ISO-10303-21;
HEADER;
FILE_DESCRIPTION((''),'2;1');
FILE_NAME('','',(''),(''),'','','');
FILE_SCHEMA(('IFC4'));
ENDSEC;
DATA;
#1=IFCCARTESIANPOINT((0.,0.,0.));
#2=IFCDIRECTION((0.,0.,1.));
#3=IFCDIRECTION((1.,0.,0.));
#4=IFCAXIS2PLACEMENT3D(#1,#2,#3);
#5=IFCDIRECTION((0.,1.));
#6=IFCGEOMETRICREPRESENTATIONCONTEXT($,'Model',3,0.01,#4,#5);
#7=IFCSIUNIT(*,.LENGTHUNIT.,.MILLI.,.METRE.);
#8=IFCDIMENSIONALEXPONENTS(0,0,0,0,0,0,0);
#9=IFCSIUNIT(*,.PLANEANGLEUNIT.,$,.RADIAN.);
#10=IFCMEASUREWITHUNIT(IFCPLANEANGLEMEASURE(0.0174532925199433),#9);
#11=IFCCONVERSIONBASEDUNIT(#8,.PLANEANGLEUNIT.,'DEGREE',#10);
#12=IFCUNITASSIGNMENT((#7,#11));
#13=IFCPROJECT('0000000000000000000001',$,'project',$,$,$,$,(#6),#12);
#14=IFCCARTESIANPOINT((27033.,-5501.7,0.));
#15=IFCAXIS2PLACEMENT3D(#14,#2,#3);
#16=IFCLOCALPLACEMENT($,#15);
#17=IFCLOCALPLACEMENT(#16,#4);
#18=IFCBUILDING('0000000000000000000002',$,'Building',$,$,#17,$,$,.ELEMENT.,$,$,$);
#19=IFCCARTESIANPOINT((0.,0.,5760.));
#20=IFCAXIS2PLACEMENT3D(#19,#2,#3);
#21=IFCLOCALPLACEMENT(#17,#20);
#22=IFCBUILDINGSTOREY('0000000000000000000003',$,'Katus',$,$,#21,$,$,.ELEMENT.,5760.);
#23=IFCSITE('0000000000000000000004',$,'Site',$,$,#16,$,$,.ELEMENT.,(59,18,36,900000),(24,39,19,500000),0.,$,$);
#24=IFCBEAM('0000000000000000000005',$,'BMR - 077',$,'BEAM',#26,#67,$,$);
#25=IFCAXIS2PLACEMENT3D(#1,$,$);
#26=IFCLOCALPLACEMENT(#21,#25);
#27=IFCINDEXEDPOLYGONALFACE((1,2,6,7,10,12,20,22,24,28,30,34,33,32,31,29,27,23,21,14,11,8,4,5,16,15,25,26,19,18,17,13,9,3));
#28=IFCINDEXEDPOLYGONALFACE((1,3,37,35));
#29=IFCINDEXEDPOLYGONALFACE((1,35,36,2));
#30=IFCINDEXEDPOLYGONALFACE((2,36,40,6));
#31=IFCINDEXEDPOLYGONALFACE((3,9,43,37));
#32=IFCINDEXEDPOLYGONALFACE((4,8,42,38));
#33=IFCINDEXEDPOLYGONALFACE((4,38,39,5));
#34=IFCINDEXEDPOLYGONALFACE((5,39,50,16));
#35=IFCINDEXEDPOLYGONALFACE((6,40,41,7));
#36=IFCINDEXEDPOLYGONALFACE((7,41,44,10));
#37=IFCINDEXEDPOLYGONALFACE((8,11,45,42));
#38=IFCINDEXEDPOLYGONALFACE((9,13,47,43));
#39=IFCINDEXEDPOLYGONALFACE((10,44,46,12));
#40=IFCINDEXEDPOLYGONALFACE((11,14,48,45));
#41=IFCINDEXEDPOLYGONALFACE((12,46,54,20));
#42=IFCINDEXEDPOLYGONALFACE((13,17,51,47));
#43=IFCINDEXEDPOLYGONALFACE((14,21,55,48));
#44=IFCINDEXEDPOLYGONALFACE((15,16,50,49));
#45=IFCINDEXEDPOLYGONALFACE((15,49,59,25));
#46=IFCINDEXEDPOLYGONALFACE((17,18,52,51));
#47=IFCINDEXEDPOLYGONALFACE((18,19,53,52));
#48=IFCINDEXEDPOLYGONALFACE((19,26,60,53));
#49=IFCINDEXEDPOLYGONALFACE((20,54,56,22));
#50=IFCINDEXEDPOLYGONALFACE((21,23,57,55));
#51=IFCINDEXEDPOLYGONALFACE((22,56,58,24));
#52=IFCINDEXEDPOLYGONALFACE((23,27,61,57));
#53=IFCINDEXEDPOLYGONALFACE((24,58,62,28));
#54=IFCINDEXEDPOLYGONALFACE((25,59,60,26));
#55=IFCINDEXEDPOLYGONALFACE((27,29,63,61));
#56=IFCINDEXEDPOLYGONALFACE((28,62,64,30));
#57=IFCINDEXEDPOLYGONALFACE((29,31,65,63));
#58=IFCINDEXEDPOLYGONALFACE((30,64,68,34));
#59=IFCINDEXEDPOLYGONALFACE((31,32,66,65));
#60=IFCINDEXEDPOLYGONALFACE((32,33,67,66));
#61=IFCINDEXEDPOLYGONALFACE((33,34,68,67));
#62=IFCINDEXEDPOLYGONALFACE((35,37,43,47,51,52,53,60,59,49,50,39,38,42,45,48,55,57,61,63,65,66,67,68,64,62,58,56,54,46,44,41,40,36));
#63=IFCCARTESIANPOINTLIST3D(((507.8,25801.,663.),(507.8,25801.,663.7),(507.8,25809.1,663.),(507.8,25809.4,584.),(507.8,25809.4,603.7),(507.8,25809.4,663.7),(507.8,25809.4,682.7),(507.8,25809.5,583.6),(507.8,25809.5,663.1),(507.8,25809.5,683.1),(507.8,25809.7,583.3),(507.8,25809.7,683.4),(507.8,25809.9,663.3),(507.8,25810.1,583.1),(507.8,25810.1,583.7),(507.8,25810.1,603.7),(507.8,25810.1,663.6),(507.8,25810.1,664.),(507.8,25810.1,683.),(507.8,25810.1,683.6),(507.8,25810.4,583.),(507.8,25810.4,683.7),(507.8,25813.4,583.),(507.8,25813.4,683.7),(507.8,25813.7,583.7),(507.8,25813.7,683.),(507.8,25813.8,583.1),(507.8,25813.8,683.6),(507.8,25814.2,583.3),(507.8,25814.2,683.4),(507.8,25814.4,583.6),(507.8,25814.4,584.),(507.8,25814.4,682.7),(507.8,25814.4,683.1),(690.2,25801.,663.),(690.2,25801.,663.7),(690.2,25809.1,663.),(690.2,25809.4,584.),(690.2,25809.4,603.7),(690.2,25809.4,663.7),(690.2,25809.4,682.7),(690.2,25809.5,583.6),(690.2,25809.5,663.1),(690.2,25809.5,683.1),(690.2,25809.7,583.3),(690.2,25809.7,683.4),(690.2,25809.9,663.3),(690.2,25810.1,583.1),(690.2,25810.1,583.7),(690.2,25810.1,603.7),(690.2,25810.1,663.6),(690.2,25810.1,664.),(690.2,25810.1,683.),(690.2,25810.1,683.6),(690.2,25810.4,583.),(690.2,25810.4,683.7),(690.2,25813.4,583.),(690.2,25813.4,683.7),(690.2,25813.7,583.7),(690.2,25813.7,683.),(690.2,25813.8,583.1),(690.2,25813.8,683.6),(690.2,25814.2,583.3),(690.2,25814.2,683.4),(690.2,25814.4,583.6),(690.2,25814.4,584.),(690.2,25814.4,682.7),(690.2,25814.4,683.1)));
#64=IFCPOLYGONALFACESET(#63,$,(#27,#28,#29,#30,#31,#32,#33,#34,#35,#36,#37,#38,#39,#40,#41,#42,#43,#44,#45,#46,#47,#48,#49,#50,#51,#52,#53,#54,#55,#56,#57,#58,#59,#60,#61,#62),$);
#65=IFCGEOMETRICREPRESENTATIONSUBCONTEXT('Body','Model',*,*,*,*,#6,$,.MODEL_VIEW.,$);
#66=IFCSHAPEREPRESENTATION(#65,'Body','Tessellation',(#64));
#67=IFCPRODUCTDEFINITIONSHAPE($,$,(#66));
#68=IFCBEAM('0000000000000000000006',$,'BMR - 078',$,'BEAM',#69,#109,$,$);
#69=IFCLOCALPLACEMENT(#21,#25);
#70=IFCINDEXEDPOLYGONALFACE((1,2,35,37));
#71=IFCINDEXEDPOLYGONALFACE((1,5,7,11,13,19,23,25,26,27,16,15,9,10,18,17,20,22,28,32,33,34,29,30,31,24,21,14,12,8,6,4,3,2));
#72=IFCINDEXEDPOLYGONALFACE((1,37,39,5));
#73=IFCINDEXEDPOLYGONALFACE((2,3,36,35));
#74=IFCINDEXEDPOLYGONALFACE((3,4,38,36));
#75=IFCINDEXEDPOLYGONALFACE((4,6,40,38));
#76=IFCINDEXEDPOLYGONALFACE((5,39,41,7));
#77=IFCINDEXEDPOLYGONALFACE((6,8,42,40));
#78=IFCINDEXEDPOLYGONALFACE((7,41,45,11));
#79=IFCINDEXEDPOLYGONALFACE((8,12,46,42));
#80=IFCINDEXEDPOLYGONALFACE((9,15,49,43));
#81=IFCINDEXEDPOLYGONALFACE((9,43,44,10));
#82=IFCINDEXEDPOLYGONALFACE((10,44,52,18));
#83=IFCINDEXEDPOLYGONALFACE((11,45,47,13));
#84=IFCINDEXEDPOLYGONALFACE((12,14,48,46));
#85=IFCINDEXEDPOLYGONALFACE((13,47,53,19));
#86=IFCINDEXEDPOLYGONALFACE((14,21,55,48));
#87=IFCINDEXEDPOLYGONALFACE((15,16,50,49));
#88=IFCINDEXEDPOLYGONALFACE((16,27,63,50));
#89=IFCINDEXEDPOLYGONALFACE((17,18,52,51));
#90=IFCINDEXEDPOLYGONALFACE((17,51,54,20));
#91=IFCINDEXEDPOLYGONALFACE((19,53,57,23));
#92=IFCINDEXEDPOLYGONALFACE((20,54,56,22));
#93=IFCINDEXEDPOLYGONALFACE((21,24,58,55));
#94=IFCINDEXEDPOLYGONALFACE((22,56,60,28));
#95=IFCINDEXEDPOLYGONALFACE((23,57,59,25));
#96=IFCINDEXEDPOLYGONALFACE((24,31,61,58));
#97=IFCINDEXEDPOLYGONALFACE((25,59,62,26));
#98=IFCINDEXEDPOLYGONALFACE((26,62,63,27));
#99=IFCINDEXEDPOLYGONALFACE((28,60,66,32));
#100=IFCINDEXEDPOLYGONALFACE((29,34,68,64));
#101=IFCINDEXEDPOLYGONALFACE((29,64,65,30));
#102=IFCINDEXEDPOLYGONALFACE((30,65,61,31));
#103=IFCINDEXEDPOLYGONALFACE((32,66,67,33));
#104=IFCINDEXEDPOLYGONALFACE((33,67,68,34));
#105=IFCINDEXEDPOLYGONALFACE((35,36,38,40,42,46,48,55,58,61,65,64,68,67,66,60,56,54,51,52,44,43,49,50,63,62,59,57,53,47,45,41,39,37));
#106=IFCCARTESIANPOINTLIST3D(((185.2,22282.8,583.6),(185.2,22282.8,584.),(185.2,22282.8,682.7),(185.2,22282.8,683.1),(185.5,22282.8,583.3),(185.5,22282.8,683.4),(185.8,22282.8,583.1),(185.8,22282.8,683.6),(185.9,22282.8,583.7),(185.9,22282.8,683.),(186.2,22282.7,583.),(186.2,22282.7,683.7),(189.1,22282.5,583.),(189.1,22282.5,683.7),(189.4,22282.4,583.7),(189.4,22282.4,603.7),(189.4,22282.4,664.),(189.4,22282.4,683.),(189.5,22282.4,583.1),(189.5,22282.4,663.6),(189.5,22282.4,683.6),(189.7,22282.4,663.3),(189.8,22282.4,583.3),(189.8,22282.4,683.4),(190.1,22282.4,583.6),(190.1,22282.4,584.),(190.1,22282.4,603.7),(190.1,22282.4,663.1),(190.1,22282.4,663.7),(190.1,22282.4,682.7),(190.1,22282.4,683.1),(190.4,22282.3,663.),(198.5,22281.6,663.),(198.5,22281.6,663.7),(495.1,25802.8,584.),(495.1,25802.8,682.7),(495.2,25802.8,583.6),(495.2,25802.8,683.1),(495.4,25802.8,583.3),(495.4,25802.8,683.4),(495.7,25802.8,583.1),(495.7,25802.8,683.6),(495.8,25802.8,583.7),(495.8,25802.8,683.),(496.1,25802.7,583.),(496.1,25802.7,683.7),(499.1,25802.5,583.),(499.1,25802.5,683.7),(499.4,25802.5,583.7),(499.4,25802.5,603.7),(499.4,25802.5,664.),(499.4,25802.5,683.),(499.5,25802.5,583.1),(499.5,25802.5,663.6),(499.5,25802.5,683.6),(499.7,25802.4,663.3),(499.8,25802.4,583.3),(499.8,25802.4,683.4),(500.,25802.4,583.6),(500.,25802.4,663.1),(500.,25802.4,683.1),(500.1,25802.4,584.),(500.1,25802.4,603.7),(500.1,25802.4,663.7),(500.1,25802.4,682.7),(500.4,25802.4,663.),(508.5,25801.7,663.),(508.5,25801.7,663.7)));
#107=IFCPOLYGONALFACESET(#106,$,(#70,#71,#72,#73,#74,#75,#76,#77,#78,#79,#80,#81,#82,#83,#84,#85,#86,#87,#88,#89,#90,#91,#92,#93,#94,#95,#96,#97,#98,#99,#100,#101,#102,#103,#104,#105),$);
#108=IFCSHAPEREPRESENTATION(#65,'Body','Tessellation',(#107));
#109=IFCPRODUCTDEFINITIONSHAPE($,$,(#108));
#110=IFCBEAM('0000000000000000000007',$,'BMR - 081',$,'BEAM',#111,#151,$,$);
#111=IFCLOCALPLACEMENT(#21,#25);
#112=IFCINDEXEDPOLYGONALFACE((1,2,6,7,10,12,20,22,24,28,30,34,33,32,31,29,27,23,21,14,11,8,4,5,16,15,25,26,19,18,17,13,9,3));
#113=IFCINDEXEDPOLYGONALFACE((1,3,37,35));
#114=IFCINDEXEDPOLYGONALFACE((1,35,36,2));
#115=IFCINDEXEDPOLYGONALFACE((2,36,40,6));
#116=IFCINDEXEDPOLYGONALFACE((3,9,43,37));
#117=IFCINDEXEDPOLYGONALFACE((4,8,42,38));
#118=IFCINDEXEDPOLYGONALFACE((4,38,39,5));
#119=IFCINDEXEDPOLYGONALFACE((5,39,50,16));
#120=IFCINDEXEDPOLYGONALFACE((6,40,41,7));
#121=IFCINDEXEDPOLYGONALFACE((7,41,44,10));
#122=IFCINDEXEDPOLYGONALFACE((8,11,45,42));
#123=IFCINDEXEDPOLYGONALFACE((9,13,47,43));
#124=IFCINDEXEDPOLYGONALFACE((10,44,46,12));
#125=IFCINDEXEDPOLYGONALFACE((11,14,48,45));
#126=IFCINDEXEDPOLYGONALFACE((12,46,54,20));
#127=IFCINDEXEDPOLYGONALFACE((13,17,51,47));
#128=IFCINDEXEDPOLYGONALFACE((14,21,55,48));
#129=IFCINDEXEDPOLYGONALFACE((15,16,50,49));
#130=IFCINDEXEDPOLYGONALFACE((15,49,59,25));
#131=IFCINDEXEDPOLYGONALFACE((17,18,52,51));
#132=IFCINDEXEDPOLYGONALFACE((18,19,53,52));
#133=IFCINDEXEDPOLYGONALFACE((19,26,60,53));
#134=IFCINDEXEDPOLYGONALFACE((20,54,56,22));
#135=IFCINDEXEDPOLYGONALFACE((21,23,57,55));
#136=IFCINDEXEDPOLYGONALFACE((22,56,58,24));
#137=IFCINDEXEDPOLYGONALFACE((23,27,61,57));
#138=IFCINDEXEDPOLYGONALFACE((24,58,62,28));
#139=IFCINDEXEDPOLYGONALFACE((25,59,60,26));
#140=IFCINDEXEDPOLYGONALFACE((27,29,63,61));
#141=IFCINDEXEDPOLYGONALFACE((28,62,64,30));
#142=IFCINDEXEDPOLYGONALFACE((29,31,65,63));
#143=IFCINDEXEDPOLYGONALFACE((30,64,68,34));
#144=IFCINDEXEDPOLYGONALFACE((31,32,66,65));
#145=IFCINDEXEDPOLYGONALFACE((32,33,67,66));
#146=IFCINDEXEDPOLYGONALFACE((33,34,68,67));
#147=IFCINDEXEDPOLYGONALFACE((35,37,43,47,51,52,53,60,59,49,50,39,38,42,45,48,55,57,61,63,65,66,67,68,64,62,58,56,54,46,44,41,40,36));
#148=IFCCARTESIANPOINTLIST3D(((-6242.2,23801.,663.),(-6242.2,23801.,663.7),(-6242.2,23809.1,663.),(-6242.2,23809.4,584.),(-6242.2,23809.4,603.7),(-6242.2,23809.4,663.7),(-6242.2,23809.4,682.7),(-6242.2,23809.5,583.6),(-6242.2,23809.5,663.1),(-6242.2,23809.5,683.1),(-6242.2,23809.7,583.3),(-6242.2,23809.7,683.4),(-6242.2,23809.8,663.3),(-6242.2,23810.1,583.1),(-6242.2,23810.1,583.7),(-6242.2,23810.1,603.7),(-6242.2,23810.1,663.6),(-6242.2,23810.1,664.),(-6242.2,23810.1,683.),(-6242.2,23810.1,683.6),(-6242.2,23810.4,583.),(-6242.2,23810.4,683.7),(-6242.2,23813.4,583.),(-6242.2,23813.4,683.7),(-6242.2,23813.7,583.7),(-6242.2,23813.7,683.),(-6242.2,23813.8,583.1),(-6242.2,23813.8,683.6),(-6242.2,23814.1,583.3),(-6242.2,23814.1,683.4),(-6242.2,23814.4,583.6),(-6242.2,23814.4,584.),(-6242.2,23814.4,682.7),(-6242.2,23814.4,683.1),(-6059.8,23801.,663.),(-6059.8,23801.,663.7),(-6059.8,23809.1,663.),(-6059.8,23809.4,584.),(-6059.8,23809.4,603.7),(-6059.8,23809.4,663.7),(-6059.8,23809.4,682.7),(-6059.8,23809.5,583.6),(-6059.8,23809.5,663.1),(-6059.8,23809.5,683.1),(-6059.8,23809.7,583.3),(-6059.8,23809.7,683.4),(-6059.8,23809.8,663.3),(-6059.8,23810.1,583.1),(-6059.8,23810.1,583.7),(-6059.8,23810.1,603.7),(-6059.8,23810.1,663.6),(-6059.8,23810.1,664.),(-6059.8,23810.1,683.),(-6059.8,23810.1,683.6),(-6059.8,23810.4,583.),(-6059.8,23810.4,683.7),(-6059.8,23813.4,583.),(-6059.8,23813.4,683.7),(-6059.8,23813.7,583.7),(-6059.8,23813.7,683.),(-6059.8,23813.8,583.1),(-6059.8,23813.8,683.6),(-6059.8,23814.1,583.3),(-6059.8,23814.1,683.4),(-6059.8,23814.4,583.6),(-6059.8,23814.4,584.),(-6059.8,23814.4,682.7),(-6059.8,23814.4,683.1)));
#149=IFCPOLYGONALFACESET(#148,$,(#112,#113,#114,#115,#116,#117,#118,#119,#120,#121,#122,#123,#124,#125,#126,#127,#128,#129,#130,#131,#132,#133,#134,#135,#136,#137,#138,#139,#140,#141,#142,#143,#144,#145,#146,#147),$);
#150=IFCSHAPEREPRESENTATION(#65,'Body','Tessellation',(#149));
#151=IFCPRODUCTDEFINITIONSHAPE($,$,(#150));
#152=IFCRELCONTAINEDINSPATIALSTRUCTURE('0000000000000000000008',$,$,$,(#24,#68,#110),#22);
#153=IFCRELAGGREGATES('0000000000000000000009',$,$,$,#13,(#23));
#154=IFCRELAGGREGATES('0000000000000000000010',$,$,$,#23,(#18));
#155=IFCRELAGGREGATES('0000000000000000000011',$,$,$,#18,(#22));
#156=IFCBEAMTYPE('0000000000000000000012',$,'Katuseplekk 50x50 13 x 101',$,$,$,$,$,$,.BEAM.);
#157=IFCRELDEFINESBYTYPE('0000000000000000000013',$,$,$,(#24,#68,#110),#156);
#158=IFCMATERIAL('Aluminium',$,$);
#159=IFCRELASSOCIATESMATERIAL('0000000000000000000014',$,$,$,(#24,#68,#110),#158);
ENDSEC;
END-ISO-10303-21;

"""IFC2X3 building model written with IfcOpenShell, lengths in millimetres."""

from ifc_helpers import new_model, entity, si_unit, converted_unit, point, direction, frame, frame_2d, origin_with_axes, place, context, subcontext, project, spatial, polyline, circle_curve, parameter, trimmed, segment, composite_curve, outline, extrude, material, type_object, element, save


model = new_model("IFC2X3")

# Units and contexts
model_context = context("Model", 3, precision=0.01, world=origin_with_axes(), true_north=direction((0.0, 1.0)))
body_context = subcontext(model_context, "Body", "Model", "MODEL_VIEW")
ifc_project = project(units=[si_unit("LENGTHUNIT", "METRE", prefix="MILLI"), converted_unit("PLANEANGLEUNIT", "DEGREE", entity("IfcPlaneAngleMeasure", 0.0174532925199433), si_unit("PLANEANGLEUNIT", "RADIAN"), dimensions=[0, 0, 0, 0, 0, 0, 0])], contexts=[model_context])

# Site, building, storey
site_placement = place(None, frame((27033.0, -5501.7, 0.0), z_axis=(0.0, 0.0, 1.0), x_axis=(1.0, 0.0, 0.0)))
site = spatial("IfcSite", under=ifc_project, at=site_placement, Name="Site", CompositionType="ELEMENT", RefLatitude=(59, 18, 36, 900000), RefLongitude=(24, 39, 19, 500000), RefElevation=0.0)
building_placement = place(site_placement, origin_with_axes())
building = spatial("IfcBuilding", under=site, at=building_placement, Name="Building", CompositionType="ELEMENT")
storey_placement = place(building_placement, frame((0.0, 0.0, 5760.0), z_axis=(0.0, 0.0, 1.0), x_axis=(1.0, 0.0, 0.0)))
storey = spatial("IfcBuildingStorey", under=building, at=storey_placement, Name="Katus", CompositionType="ELEMENT", Elevation=5760.0)

# Beams
ifc_material_1 = material(Name="Aluminium")
beam_type = type_object("IfcBeamType", Name="Katuseplekk 50x50 13 x 101", PredefinedType="BEAM")
beam_1_placement = place(storey_placement, frame((690.2, 25801.7, 663.0), z_axis=(0.0, 0.0, 1.0), x_axis=(0.0, 1.0, 0.0)))
element("IfcBeam", 1, at=beam_1_placement, inside=storey, type_object=beam_type, material=ifc_material_1, Name="BMR - 077", ObjectType="BEAM", context=body_context, shape_type="SweptSolid", body=[
    extrude(outline(composite_curve([segment(polyline([(-0.7, 0.0), (7.4, 0.0)]), True, "CONTINUOUS"), segment(trimmed(circle_curve(frame_2d((7.4, 1.0), x_axis=(0.0, -1.0)), 1.0), [point((7.4, 0.0)), parameter(0.0)], [point((8.4, 1.0)), parameter(90.0)], True, "CARTESIAN"), True, "CONTINUOUS"), segment(polyline([(8.4, 1.0), (8.4, 20.0), (12.0, 20.0), (12.0, -79.3), (8.4, -79.3), (8.4, -59.3), (7.7, -59.3), (7.7, -79.0)]), True, "CONTINUOUS"), segment(trimmed(circle_curve(frame_2d((8.7, -79.0), x_axis=(-1.0, 0.0)), 1.0), [point((7.7, -79.0)), parameter(0.0)], [point((8.7, -80.0)), parameter(90.0)], True, "CARTESIAN"), True, "CONTINUOUS"), segment(polyline([(8.7, -80.0), (11.7, -80.0)]), True, "CONTINUOUS"), segment(trimmed(circle_curve(frame_2d((11.7, -79.0), x_axis=(0.0, -1.0)), 1.0), [point((11.7, -80.0)), parameter(0.0)], [point((12.7, -79.0)), parameter(90.0)], True, "CARTESIAN"), True, "CONTINUOUS"), segment(polyline([(12.7, -79.0), (12.7, 19.7)]), True, "CONTINUOUS"), segment(trimmed(circle_curve(frame_2d((11.7, 19.7), x_axis=(1.0, 0.0)), 1.0), [point((12.7, 19.7)), parameter(0.0)], [point((11.7, 20.7)), parameter(90.0)], True, "CARTESIAN"), True, "CONTINUOUS"), segment(polyline([(11.7, 20.7), (8.7, 20.7)]), True, "CONTINUOUS"), segment(trimmed(circle_curve(frame_2d((8.7, 19.7), x_axis=(0.0, 1.0)), 1.0), [point((8.7, 20.7)), parameter(0.0)], [point((7.7, 19.7)), parameter(90.0)], True, "CARTESIAN"), True, "CONTINUOUS"), segment(polyline([(7.7, 19.7), (7.7, 0.7), (-0.7, 0.7), (-0.7, 0.0)]), True, "CONTINUOUS")], self_intersect=False)), frame((0.0, 182.4, 0.0), z_axis=(0.0, -1.0, 0.0), x_axis=(1.0, 0.0, 0.0)), (0.0, 0.0, 1.0), 182.4),
])
beam_2_placement = place(storey_placement, frame((507.8, 25801.7, 663.0), z_axis=(0.0, 0.0, 1.0), x_axis=(-0.996146, 0.087713, 0.0)))
element("IfcBeam", 2, at=beam_2_placement, inside=storey, type_object=beam_type, material=ifc_material_1, Name="BMR - 078", ObjectType="BEAM", context=body_context, shape_type="SweptSolid", body=[
    extrude(outline(composite_curve([segment(polyline([(-0.7, 0.0), (7.4, 0.0)]), True, "CONTINUOUS"), segment(trimmed(circle_curve(frame_2d((7.4, 1.0), x_axis=(0.0, -1.0)), 1.0), [point((7.4, 0.0)), parameter(0.0)], [point((8.4, 1.0)), parameter(90.0)], True, "CARTESIAN"), True, "CONTINUOUS"), segment(polyline([(8.4, 1.0), (8.4, 20.0), (12.0, 20.0), (12.0, -79.3), (8.4, -79.3), (8.4, -59.3), (7.7, -59.3), (7.7, -79.0)]), True, "CONTINUOUS"), segment(trimmed(circle_curve(frame_2d((8.7, -79.0), x_axis=(-1.0, 0.0)), 1.0), [point((7.7, -79.0)), parameter(0.0)], [point((8.7, -80.0)), parameter(90.0)], True, "CARTESIAN"), True, "CONTINUOUS"), segment(polyline([(8.7, -80.0), (11.7, -80.0)]), True, "CONTINUOUS"), segment(trimmed(circle_curve(frame_2d((11.7, -79.0), x_axis=(0.0, -1.0)), 1.0), [point((11.7, -80.0)), parameter(0.0)], [point((12.7, -79.0)), parameter(90.0)], True, "CARTESIAN"), True, "CONTINUOUS"), segment(polyline([(12.7, -79.0), (12.7, 19.7)]), True, "CONTINUOUS"), segment(trimmed(circle_curve(frame_2d((11.7, 19.7), x_axis=(1.0, 0.0)), 1.0), [point((12.7, 19.7)), parameter(0.0)], [point((11.7, 20.7)), parameter(90.0)], True, "CARTESIAN"), True, "CONTINUOUS"), segment(polyline([(11.7, 20.7), (8.7, 20.7)]), True, "CONTINUOUS"), segment(trimmed(circle_curve(frame_2d((8.7, 19.7), x_axis=(0.0, 1.0)), 1.0), [point((8.7, 20.7)), parameter(0.0)], [point((7.7, 19.7)), parameter(90.0)], True, "CARTESIAN"), True, "CONTINUOUS"), segment(polyline([(7.7, 19.7), (7.7, 0.7), (-0.7, 0.7), (-0.7, 0.0)]), True, "CONTINUOUS")], self_intersect=False)), frame((0.0, 3533.6, 0.0), z_axis=(0.0, -1.0, 0.0), x_axis=(1.0, 0.0, 0.0)), (0.0, 0.0, 1.0), 3533.6),
])
beam_3_placement = place(storey_placement, frame((-6059.8, 23801.7, 663.0), z_axis=(0.0, 0.0, 1.0), x_axis=(0.0, 1.0, 0.0)))
element("IfcBeam", 3, at=beam_3_placement, inside=storey, type_object=beam_type, material=ifc_material_1, Name="BMR - 081", ObjectType="BEAM", context=body_context, shape_type="SweptSolid", body=[
    extrude(outline(composite_curve([segment(polyline([(-0.7, 0.0), (7.4, 0.0)]), True, "CONTINUOUS"), segment(trimmed(circle_curve(frame_2d((7.4, 1.0), x_axis=(0.0, -1.0)), 1.0), [point((7.4, 0.0)), parameter(0.0)], [point((8.4, 1.0)), parameter(90.0)], True, "CARTESIAN"), True, "CONTINUOUS"), segment(polyline([(8.4, 1.0), (8.4, 20.0), (12.0, 20.0), (12.0, -79.3), (8.4, -79.3), (8.4, -59.3), (7.7, -59.3), (7.7, -79.0)]), True, "CONTINUOUS"), segment(trimmed(circle_curve(frame_2d((8.7, -79.0), x_axis=(-1.0, 0.0)), 1.0), [point((7.7, -79.0)), parameter(0.0)], [point((8.7, -80.0)), parameter(90.0)], True, "CARTESIAN"), True, "CONTINUOUS"), segment(polyline([(8.7, -80.0), (11.7, -80.0)]), True, "CONTINUOUS"), segment(trimmed(circle_curve(frame_2d((11.7, -79.0), x_axis=(0.0, -1.0)), 1.0), [point((11.7, -80.0)), parameter(0.0)], [point((12.7, -79.0)), parameter(90.0)], True, "CARTESIAN"), True, "CONTINUOUS"), segment(polyline([(12.7, -79.0), (12.7, 19.7)]), True, "CONTINUOUS"), segment(trimmed(circle_curve(frame_2d((11.7, 19.7), x_axis=(1.0, 0.0)), 1.0), [point((12.7, 19.7)), parameter(0.0)], [point((11.7, 20.7)), parameter(90.0)], True, "CARTESIAN"), True, "CONTINUOUS"), segment(polyline([(11.7, 20.7), (8.7, 20.7)]), True, "CONTINUOUS"), segment(trimmed(circle_curve(frame_2d((8.7, 19.7), x_axis=(0.0, 1.0)), 1.0), [point((8.7, 20.7)), parameter(0.0)], [point((7.7, 19.7)), parameter(90.0)], True, "CARTESIAN"), True, "CONTINUOUS"), segment(polyline([(7.7, 19.7), (7.7, 0.7), (-0.7, 0.7), (-0.7, 0.0)]), True, "CONTINUOUS")], self_intersect=False)), frame((0.0, 182.4, 0.0), z_axis=(0.0, -1.0, 0.0), x_axis=(1.0, 0.0, 0.0)), (0.0, 0.0, 1.0), 182.4),
])

save(model, "model.ifc")
